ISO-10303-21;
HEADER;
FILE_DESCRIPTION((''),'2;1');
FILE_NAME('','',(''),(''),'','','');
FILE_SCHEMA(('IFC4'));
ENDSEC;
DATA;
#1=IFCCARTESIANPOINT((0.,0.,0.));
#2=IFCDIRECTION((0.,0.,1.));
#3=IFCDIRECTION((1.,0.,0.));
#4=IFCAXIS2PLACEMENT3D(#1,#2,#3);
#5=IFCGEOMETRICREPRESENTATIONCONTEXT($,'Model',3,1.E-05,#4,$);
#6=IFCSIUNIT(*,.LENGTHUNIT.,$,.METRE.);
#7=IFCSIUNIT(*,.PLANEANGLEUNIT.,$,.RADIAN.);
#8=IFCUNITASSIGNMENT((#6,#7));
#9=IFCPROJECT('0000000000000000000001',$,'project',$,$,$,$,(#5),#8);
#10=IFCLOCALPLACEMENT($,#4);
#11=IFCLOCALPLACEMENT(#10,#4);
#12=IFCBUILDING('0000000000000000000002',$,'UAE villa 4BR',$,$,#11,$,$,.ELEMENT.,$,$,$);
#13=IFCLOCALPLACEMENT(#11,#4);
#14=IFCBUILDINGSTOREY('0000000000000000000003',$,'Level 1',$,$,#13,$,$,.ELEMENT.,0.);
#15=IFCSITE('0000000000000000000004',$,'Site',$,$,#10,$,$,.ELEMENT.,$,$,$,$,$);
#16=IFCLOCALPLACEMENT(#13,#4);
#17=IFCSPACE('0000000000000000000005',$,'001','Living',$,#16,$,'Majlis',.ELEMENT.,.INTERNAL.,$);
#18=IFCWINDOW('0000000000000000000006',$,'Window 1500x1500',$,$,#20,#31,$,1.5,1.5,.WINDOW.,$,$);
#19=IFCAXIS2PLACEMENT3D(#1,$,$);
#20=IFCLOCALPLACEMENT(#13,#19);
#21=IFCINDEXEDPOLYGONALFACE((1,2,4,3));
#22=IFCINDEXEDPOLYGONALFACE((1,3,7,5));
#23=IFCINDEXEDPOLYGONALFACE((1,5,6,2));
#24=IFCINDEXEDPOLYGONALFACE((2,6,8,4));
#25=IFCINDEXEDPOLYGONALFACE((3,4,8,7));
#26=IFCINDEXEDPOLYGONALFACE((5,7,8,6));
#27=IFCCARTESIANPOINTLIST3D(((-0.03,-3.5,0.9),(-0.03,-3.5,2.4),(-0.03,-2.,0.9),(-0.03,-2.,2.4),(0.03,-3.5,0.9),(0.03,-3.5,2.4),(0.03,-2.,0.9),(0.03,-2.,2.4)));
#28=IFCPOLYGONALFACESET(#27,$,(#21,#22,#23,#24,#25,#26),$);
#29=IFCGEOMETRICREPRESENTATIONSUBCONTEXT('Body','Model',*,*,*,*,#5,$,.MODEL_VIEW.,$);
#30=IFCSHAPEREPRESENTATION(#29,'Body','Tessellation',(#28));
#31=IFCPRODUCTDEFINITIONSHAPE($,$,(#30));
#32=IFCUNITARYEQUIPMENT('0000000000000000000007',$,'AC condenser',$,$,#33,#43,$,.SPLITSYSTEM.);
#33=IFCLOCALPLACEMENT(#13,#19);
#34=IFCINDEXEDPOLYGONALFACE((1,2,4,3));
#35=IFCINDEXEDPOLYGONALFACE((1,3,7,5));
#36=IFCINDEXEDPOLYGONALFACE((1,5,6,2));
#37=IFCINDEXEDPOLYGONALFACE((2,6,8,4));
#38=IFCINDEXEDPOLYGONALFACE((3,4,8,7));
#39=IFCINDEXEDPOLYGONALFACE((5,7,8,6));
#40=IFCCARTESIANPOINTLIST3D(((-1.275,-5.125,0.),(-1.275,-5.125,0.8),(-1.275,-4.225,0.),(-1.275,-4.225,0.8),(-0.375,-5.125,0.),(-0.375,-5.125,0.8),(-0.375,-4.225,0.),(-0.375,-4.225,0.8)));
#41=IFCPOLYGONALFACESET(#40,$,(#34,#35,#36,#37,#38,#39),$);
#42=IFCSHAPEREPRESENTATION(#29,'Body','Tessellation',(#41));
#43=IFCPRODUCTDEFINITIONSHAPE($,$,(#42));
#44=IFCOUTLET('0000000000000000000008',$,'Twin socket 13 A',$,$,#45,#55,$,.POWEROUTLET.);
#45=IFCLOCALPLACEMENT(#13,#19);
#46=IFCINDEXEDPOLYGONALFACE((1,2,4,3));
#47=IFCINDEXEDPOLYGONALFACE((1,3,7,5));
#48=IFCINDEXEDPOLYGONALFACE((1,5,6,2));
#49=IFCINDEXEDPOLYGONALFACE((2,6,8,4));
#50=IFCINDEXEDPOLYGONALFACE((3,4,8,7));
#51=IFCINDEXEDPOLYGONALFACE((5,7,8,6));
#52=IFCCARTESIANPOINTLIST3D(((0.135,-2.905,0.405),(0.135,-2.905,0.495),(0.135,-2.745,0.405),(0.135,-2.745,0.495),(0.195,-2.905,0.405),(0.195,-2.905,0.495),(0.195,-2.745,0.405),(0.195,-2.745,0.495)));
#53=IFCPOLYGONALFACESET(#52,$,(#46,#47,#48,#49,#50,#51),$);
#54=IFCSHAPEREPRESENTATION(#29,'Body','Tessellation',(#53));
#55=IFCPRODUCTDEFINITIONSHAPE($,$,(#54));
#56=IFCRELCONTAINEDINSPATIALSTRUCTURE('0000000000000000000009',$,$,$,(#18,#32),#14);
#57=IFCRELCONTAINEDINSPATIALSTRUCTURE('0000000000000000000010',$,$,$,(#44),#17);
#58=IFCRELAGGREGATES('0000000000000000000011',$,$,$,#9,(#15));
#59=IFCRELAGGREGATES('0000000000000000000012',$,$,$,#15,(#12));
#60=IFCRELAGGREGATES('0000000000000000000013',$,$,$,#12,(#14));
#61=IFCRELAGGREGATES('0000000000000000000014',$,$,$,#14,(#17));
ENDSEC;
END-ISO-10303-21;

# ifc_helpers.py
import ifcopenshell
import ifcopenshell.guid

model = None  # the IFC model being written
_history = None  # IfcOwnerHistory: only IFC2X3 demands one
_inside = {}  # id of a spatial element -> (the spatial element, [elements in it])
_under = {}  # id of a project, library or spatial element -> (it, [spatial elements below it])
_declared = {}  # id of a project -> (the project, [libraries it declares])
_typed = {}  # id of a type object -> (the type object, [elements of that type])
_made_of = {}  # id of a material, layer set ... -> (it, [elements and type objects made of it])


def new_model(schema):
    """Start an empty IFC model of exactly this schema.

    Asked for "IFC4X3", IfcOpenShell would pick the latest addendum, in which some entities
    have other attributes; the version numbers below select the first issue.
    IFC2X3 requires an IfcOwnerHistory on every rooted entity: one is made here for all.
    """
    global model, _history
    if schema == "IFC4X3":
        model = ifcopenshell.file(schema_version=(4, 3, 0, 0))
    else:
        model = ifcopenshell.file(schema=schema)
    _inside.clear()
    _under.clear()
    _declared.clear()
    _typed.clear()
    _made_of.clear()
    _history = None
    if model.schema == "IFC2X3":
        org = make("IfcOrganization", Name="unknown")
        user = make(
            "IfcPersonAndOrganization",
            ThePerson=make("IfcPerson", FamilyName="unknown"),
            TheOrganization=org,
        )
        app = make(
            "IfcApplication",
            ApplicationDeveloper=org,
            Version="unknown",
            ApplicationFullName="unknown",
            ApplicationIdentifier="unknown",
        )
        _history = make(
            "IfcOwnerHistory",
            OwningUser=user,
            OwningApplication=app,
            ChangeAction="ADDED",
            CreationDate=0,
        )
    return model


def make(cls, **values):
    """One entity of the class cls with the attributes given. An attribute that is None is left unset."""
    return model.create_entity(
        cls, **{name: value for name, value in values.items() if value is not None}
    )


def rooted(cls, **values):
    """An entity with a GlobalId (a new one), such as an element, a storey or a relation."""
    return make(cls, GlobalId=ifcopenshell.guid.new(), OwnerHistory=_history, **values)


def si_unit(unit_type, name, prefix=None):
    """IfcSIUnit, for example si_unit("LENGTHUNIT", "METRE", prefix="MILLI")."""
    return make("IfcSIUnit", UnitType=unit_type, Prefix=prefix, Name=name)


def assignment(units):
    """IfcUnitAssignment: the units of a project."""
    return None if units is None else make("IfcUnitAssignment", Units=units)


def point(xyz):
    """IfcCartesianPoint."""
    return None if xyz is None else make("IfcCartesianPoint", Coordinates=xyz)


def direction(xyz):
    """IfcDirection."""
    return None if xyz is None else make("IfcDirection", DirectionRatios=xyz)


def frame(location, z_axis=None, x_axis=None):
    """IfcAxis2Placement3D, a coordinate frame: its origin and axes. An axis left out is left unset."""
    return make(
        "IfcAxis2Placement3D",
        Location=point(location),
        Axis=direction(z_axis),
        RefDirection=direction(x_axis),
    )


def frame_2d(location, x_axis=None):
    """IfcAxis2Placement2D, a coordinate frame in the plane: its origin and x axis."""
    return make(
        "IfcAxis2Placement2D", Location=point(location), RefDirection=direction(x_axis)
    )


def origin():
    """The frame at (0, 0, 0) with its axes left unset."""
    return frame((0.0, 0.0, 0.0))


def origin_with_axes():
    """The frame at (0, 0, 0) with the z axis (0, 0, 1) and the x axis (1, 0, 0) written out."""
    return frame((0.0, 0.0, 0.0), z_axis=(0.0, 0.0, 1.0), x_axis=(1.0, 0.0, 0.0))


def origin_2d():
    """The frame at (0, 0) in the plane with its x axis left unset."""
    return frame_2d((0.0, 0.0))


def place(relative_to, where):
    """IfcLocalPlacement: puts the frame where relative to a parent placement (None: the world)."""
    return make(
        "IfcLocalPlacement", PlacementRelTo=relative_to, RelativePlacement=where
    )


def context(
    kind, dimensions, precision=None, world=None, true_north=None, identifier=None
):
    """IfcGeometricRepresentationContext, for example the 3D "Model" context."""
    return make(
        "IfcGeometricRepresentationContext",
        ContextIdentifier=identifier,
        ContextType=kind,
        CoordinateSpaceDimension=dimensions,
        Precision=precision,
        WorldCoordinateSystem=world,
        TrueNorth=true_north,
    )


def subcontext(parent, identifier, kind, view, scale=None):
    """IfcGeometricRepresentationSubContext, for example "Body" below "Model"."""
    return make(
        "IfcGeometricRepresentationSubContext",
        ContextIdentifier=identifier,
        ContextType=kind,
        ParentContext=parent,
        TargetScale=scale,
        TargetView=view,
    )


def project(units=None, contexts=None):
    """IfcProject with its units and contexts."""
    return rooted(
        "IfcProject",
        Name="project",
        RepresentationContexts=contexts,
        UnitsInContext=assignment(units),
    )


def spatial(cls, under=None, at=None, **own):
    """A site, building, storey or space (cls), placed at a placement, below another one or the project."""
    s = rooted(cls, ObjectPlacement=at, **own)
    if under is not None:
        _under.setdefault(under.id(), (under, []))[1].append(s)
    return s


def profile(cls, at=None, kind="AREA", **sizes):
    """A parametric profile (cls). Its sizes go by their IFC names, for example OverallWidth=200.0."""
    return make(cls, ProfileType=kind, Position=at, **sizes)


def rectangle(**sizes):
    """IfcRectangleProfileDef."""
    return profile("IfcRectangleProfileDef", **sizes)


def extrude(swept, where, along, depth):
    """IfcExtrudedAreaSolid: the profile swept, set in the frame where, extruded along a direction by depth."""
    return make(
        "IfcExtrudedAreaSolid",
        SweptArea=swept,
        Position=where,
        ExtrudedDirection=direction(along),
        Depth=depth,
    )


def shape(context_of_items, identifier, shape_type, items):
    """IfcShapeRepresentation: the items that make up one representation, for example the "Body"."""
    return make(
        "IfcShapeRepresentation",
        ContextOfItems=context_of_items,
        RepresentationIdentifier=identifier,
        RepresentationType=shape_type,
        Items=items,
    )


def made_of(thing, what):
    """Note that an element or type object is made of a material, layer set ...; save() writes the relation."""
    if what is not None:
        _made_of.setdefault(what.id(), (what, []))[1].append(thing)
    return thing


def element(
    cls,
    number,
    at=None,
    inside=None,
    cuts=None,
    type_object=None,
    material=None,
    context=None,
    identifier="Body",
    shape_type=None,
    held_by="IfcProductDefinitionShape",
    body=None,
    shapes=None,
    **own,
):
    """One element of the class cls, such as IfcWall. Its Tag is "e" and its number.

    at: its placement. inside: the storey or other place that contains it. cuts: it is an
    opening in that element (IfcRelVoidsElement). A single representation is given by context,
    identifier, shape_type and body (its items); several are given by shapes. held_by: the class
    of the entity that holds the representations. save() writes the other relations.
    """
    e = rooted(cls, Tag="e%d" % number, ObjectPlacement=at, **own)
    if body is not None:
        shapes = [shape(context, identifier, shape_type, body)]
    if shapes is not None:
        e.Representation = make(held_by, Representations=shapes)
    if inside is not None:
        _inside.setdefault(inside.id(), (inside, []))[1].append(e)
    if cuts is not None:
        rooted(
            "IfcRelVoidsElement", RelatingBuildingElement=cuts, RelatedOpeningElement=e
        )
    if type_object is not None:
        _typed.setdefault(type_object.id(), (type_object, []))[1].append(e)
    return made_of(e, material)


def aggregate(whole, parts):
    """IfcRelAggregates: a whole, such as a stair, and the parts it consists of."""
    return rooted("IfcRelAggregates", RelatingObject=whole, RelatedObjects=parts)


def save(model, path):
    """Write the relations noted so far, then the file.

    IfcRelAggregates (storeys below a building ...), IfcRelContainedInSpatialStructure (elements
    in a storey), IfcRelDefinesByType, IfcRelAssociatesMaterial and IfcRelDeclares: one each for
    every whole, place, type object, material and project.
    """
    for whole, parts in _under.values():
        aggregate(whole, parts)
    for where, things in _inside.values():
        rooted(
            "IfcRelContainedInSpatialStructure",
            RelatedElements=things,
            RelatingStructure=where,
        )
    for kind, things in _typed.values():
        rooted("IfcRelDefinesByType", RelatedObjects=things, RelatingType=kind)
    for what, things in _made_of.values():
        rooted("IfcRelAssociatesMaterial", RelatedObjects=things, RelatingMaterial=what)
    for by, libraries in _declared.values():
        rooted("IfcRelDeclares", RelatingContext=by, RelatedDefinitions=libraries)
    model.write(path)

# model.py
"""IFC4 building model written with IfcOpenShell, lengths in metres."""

from ifc_helpers import new_model, si_unit, frame, origin, origin_with_axes, origin_2d, place, context, subcontext, project, spatial, rectangle, extrude, element, save


model = new_model("IFC4")

# Units and contexts
model_context = context("Model", 3, precision=1e-05, world=origin_with_axes())
body_context = subcontext(model_context, "Body", "Model", "MODEL_VIEW")
ifc_project = project(units=[si_unit("LENGTHUNIT", "METRE"), si_unit("PLANEANGLEUNIT", "RADIAN")], contexts=[model_context])

# Site, building, storey
site_placement = place(None, origin_with_axes())
site = spatial("IfcSite", under=ifc_project, at=site_placement, Name="Site", CompositionType="ELEMENT")
building_placement = place(site_placement, origin_with_axes())
building = spatial("IfcBuilding", under=site, at=building_placement, Name="UAE villa 4BR", CompositionType="ELEMENT")
storey_placement = place(building_placement, origin_with_axes())
storey = spatial("IfcBuildingStorey", under=building, at=storey_placement, Name="Level 1", CompositionType="ELEMENT", Elevation=0.0)

# Window
window_1_placement = place(storey_placement, frame((0.0, -2.75, 0.9), z_axis=(0.0, 0.0, 1.0), x_axis=(0.0, 1.0, 0.0)))
element("IfcWindow", 1, at=window_1_placement, inside=storey, Name="Window 1500x1500", OverallHeight=1.5, OverallWidth=1.5, PredefinedType="WINDOW", context=body_context, shape_type="SweptSolid", body=[
    extrude(rectangle(XDim=1.5, YDim=0.06, at=origin_2d()), origin(), (0.0, 0.0, 1.0), 1.5),
])

# Unitary equipment
unitary_equipment_placement = place(storey_placement, frame((-0.825, -4.675, 0.0), z_axis=(0.0, 0.0, 1.0), x_axis=(0.0, -1.0, 0.0)))
element("IfcUnitaryEquipment", 2, at=unitary_equipment_placement, inside=storey, Name="AC condenser", PredefinedType="SPLITSYSTEM", context=body_context, shape_type="SweptSolid", body=[
    extrude(rectangle(XDim=0.9, YDim=0.9, at=origin_2d()), origin(), (0.0, 0.0, 1.0), 0.8),
])

# Shared definitions
space_placement = place(storey_placement, origin_with_axes())
space = spatial("IfcSpace", under=storey, at=space_placement, Name="001", Description="Living", LongName="Majlis", CompositionType="ELEMENT", PredefinedType="INTERNAL")

# Outlet
outlet_placement = place(storey_placement, frame((0.165, -2.825, 0.405), z_axis=(0.0, 0.0, 1.0), x_axis=(0.0, 1.0, 0.0)))
element("IfcOutlet", 3, at=outlet_placement, inside=space, Name="Twin socket 13 A", PredefinedType="POWEROUTLET", context=body_context, shape_type="SweptSolid", body=[
    extrude(rectangle(XDim=0.16, YDim=0.06, at=origin_2d()), origin(), (0.0, 0.0, 1.0), 0.09),
])

save(model, "model.ifc")
